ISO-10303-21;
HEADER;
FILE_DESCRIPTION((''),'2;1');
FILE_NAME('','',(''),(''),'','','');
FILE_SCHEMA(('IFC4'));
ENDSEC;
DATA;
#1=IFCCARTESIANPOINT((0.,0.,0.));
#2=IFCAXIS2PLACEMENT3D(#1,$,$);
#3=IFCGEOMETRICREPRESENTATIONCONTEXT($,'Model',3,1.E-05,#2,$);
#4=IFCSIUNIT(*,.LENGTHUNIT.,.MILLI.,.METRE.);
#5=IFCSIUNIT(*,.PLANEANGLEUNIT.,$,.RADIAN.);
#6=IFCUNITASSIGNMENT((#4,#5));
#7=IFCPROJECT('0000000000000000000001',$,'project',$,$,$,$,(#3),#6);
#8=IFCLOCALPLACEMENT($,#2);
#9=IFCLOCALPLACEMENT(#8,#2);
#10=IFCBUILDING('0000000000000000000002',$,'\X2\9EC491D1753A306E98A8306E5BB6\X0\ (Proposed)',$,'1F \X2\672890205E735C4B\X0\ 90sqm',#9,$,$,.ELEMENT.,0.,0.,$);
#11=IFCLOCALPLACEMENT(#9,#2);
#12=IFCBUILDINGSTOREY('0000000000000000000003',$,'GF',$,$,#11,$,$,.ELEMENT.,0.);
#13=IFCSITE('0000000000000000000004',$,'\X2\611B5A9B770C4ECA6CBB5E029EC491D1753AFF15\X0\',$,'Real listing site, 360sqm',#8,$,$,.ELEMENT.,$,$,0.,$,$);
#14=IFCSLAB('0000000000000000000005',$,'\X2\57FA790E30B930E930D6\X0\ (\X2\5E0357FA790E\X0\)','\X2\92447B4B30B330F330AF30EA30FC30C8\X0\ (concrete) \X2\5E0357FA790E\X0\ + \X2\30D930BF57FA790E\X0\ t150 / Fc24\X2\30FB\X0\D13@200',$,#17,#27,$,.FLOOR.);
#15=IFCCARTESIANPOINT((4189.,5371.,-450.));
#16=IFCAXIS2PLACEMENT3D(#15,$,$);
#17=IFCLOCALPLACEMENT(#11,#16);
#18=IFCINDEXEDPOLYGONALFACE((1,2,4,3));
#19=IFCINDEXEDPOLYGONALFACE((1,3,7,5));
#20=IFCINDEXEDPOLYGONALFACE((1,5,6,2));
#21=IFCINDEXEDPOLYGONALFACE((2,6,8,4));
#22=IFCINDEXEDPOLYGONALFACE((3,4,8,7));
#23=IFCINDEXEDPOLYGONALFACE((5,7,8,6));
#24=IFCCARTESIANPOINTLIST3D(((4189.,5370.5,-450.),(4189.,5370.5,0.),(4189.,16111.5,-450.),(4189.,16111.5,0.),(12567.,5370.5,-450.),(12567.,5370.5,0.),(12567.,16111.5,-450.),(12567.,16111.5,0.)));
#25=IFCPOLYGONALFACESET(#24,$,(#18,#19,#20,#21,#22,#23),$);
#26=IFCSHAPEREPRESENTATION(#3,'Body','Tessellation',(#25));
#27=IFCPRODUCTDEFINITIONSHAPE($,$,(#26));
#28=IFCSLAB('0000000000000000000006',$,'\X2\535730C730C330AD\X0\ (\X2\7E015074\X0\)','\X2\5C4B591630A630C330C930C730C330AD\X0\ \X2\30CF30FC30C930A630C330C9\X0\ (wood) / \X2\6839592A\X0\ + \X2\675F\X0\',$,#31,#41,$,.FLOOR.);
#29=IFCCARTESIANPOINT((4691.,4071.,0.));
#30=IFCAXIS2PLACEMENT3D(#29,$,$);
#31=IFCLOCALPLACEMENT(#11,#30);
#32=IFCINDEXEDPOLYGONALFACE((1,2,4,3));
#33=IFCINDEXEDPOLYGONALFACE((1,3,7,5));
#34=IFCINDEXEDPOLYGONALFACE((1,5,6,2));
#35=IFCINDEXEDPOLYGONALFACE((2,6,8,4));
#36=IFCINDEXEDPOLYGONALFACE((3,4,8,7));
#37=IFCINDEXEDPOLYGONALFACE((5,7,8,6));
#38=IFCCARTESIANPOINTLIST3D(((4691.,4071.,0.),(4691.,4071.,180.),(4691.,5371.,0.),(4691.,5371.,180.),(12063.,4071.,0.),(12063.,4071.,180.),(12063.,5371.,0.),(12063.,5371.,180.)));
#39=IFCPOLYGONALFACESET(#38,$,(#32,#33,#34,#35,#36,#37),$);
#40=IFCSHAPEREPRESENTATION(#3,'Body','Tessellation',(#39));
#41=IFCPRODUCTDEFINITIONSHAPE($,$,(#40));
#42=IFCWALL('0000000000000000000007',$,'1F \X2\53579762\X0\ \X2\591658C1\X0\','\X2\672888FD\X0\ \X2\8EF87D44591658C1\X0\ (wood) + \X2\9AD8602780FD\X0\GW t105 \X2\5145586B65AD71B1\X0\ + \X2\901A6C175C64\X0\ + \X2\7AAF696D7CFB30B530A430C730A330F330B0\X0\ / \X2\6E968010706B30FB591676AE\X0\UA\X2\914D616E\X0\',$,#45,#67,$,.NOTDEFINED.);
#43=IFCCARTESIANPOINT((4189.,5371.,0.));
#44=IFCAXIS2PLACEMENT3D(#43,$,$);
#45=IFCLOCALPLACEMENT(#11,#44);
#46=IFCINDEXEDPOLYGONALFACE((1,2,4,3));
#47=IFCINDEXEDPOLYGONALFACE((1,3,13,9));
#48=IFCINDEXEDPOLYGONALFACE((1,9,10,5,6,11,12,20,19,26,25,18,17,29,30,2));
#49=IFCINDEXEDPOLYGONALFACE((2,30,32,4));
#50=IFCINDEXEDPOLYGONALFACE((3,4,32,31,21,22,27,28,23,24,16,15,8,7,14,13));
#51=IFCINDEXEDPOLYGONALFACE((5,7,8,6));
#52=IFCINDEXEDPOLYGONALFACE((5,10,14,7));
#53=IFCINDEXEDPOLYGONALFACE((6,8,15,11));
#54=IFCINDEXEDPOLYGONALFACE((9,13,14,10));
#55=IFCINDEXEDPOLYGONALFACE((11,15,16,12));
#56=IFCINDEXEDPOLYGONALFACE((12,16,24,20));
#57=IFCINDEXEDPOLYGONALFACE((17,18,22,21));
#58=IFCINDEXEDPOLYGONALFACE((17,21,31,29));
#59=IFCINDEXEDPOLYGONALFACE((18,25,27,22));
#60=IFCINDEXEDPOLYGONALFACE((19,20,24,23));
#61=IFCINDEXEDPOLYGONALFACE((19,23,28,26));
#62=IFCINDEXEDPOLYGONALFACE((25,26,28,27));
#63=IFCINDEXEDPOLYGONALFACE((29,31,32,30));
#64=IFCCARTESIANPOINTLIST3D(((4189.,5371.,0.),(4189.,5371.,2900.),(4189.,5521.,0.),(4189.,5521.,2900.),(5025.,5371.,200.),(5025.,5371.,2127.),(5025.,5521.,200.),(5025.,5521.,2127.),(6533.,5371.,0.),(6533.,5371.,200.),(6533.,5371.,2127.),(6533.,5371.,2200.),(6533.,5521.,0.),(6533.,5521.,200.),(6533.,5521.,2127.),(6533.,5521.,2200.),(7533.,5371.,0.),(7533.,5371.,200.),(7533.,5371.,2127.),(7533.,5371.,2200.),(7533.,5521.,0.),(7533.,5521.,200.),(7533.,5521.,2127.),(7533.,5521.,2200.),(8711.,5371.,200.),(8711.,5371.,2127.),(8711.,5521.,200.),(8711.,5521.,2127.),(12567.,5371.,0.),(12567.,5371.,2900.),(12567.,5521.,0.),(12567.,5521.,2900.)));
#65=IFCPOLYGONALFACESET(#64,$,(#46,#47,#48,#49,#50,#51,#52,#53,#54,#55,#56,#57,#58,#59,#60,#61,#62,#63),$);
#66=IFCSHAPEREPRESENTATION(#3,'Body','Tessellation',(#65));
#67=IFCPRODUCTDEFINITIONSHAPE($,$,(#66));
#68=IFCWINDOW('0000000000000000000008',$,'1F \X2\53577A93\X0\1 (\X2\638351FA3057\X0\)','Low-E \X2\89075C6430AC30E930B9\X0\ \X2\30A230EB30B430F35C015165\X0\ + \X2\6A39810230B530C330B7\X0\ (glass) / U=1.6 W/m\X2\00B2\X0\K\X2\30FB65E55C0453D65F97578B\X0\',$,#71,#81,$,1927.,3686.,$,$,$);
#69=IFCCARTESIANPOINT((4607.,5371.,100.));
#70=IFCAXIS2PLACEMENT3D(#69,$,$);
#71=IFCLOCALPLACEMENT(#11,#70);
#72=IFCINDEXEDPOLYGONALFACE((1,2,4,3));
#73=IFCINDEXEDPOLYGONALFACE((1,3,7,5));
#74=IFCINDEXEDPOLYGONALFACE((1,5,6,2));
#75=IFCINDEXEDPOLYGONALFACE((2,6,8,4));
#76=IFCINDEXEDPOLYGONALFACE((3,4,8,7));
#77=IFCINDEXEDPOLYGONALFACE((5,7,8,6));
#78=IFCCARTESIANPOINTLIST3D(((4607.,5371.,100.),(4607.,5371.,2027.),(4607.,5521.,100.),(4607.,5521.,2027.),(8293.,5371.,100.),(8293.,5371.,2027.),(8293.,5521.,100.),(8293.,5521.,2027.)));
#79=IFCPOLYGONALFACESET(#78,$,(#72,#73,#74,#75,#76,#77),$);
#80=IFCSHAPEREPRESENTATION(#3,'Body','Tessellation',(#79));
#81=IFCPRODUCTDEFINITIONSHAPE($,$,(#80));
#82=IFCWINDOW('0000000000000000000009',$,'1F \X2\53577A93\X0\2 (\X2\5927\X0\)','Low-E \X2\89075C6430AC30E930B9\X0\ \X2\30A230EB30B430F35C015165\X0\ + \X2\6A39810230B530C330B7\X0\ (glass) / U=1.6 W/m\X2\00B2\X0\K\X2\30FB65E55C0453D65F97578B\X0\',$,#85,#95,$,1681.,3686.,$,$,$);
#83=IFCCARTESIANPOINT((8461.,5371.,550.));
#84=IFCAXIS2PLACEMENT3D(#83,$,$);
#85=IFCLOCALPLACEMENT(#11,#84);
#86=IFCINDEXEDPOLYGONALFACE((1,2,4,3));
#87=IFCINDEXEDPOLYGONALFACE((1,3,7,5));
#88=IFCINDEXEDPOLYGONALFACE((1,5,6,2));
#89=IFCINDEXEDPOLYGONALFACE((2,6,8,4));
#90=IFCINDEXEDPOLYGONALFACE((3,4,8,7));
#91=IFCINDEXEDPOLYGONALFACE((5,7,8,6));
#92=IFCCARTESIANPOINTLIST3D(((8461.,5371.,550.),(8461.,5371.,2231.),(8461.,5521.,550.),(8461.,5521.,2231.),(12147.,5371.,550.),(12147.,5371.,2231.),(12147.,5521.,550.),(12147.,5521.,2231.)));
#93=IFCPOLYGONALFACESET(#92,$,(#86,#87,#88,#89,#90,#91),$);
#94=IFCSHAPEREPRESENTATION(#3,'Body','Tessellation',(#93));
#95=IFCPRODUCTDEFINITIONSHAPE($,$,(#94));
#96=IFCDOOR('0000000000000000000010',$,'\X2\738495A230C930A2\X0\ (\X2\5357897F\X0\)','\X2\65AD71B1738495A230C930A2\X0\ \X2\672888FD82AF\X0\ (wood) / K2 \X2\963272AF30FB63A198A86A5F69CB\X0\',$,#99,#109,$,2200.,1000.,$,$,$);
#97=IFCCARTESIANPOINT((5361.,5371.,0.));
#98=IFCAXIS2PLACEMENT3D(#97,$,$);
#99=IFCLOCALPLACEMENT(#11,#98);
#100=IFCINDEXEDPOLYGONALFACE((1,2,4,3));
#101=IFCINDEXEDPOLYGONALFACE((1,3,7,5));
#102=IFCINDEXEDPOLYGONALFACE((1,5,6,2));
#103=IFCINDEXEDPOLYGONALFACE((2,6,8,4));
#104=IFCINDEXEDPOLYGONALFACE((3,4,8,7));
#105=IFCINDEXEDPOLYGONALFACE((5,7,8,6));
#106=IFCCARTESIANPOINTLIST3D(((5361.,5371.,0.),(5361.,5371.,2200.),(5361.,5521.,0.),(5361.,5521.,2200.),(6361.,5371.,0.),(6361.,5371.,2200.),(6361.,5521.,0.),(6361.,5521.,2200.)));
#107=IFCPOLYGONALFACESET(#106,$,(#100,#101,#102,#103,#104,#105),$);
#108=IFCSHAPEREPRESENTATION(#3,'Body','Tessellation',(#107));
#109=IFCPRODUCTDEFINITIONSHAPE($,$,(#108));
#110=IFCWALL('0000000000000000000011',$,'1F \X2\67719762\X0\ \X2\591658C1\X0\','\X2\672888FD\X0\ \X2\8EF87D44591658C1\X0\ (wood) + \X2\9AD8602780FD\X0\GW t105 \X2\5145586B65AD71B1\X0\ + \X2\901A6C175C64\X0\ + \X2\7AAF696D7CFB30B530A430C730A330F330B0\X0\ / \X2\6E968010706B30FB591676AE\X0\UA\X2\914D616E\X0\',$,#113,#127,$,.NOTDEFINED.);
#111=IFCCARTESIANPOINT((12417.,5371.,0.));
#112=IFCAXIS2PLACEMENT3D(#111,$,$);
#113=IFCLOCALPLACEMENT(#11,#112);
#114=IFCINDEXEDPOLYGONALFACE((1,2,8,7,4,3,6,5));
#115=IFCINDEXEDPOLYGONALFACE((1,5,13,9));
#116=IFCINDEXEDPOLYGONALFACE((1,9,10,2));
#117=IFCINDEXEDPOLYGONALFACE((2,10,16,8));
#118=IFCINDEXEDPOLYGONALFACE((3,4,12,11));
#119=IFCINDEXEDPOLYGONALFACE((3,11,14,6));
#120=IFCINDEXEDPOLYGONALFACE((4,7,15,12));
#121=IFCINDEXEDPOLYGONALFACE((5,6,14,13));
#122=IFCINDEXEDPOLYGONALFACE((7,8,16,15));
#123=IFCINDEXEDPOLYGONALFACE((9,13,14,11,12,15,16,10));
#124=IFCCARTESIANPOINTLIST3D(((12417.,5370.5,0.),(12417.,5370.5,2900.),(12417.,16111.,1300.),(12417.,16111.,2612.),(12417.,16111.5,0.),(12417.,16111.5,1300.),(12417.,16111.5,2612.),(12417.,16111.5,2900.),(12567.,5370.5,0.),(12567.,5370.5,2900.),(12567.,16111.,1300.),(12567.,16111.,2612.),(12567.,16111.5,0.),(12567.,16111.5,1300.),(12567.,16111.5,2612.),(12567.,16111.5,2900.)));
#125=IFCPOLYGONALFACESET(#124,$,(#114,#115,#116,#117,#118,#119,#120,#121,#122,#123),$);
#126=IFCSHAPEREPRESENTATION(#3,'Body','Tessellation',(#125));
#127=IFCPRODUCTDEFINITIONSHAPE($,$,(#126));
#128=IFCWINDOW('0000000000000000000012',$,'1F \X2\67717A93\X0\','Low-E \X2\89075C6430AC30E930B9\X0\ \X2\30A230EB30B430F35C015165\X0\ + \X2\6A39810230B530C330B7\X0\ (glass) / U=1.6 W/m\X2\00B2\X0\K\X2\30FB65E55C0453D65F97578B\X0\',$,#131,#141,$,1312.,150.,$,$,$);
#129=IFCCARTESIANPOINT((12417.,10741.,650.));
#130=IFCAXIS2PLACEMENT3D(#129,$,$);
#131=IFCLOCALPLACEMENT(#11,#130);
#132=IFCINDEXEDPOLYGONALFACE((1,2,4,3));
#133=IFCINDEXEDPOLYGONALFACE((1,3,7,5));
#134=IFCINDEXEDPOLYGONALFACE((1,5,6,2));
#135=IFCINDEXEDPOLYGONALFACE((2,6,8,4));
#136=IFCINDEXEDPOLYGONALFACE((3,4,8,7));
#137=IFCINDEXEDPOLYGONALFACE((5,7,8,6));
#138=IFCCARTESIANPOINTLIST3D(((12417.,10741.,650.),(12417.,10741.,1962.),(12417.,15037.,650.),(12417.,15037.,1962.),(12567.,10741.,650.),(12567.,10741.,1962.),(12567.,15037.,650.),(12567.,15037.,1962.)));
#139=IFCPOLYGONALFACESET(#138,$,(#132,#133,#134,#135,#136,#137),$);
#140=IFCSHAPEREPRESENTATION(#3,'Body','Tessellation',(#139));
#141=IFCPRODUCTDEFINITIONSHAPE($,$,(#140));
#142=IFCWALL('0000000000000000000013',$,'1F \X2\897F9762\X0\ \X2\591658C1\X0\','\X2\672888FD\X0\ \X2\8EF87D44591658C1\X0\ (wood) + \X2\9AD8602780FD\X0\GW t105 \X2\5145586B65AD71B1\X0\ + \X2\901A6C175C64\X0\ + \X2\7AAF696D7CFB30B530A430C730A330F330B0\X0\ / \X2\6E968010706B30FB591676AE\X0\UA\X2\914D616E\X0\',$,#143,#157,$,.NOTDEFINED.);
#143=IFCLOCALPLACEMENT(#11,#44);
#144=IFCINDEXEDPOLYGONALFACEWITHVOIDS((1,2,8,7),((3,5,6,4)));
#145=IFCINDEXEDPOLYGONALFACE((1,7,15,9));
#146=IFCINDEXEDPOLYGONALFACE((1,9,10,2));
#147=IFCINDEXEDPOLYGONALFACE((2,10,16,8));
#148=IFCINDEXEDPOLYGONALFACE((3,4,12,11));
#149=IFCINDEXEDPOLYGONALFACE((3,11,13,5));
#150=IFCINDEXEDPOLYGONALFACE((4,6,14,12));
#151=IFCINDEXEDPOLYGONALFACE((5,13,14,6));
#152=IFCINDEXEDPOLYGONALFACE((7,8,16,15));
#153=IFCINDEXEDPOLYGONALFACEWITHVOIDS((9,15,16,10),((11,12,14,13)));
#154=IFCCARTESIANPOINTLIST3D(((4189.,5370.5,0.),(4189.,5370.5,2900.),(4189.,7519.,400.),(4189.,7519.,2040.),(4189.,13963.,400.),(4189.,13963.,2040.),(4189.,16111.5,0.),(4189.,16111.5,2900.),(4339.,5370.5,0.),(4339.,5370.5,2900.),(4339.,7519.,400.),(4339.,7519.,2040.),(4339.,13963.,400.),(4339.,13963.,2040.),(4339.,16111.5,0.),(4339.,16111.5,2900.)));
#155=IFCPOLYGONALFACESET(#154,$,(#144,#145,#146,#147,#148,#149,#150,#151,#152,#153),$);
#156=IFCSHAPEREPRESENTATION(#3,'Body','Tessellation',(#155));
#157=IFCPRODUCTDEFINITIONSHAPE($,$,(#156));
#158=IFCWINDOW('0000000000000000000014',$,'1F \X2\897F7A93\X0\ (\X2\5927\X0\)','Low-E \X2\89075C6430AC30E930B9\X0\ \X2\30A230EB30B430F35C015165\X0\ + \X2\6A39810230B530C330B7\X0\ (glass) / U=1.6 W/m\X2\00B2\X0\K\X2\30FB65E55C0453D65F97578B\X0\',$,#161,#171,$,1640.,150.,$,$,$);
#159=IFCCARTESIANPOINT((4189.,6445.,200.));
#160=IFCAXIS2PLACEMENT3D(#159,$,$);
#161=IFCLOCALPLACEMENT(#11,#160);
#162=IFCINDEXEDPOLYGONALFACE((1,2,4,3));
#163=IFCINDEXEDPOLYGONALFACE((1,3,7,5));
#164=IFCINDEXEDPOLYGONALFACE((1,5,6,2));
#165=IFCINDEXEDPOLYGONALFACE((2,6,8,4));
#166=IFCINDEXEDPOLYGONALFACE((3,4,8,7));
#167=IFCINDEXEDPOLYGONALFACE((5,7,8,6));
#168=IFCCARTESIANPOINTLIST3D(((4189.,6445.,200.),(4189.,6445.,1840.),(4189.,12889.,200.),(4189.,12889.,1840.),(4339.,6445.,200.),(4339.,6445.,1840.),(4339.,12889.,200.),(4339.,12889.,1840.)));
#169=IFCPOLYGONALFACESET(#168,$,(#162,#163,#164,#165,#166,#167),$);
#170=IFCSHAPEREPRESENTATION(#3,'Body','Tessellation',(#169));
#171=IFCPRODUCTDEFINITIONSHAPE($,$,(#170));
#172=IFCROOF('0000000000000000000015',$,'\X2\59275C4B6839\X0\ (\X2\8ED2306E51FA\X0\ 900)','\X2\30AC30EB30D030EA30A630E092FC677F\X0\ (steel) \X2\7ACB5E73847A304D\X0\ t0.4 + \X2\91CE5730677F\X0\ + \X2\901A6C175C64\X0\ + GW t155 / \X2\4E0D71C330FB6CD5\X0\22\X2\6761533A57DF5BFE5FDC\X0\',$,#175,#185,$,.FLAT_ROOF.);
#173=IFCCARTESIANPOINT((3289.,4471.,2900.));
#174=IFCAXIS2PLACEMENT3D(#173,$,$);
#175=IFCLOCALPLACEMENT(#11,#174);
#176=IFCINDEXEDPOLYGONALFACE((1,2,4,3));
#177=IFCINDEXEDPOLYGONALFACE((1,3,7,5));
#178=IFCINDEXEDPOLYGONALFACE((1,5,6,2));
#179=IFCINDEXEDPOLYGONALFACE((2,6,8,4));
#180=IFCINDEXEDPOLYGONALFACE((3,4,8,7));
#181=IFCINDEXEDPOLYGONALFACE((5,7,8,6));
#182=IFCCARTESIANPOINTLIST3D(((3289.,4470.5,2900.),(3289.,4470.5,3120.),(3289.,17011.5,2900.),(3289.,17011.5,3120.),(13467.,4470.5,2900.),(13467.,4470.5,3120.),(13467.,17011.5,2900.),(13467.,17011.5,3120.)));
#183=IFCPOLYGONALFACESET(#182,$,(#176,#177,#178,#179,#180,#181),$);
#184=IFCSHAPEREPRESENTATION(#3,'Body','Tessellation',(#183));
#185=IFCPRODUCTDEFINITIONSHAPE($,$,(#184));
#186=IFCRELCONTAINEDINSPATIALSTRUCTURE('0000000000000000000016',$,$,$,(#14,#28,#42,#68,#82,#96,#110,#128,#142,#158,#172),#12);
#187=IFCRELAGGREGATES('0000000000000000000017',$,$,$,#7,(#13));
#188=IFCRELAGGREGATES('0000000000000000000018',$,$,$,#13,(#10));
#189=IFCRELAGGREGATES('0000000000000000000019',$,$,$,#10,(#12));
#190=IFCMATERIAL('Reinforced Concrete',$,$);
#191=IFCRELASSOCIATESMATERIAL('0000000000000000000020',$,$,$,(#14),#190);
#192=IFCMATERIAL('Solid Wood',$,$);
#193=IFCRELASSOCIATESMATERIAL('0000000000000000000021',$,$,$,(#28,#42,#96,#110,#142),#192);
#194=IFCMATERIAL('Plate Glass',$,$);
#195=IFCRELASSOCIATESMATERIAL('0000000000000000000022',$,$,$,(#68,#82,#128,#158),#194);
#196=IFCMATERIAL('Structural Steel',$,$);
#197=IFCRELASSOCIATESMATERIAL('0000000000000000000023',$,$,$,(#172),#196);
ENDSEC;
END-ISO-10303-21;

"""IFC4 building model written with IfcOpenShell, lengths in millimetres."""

from ifc_helpers import new_model, si_unit, frame, frame_2d, origin, place, context, project, spatial, rectangle, extrude, material, element, fill, save


model = new_model("IFC4")

# Units and contexts
model_context = context("Model", 3, precision=1e-05, world=origin())
ifc_project = project(units=[si_unit("LENGTHUNIT", "METRE", prefix="MILLI"), si_unit("PLANEANGLEUNIT", "RADIAN")], contexts=[model_context])

# Site, building, storey
site_placement = place(None, origin())
site = spatial("IfcSite", under=ifc_project, at=site_placement, Name="愛媛県今治市黄金町５", ObjectType="Real listing site, 360sqm", CompositionType="ELEMENT", RefElevation=0.0)
building_placement = place(site_placement, origin())
building = spatial("IfcBuilding", under=site, at=building_placement, Name="黄金町の風の家 (Proposed)", ObjectType="1F 木造平屋 90sqm", CompositionType="ELEMENT", ElevationOfRefHeight=0.0, ElevationOfTerrain=0.0)
storey_placement = place(building_placement, origin())
storey = spatial("IfcBuildingStorey", under=building, at=storey_placement, Name="GF", CompositionType="ELEMENT", Elevation=0.0)

# Slabs
ifc_material_1 = material(Name="Reinforced Concrete")
slab_1_placement = place(storey_placement, frame((4189.0, 5371.0, -450.0)))
element("IfcSlab", 1, at=slab_1_placement, inside=storey, material=ifc_material_1, Name="基礎スラブ (布基礎)", Description="鉄筋コンクリート (concrete) 布基礎 + ベタ基礎 t150 / Fc24・D13@200", PredefinedType="FLOOR", context=model_context, shape_type="SweptSolid", body=[
    extrude(rectangle(XDim=8378.0, YDim=10741.0, at=frame_2d((4189.0, 5370.0))), frame((4189.0, 5371.0, -450.0)), (0.0, 0.0, 1.0), 450.0),
])
ifc_material_2 = material(Name="Solid Wood")
slab_2_placement = place(storey_placement, frame((4691.0, 4071.0, 0.0)))
element("IfcSlab", 2, at=slab_2_placement, inside=storey, material=ifc_material_2, Name="南デッキ (縁側)", Description="屋外ウッドデッキ ハードウッド (wood) / 根太 + 束", PredefinedType="FLOOR", context=model_context, shape_type="SweptSolid", body=[
    extrude(rectangle(XDim=7372.0, YDim=1300.0, at=frame_2d((3686.0, 650.0))), frame((4691.0, 4071.0, 0.0)), (0.0, 0.0, 1.0), 180.0),
])

# Wall, openings, windows, door
wall_1_placement = place(storey_placement, frame((4189.0, 5371.0, 0.0)))
wall_1 = element("IfcWall", 3, at=wall_1_placement, inside=storey, material=ifc_material_2, Name="1F 南面 外壁", Description="木製 軸組外壁 (wood) + 高性能GW t105 充填断熱 + 通気層 + 窯業系サイディング / 準耐火・外皮UA配慮", PredefinedType="NOTDEFINED", context=model_context, shape_type="SweptSolid", body=[
    extrude(rectangle(XDim=8378.0, YDim=150.0, at=frame_2d((4189.0, 75.0))), frame((4189.0, 5371.0, 0.0)), (0.0, 0.0, 1.0), 2900.0),
])
opening_1_placement = place(storey_placement, frame((4607.0, 5371.0, 100.0)))
opening_1 = element("IfcOpeningElement", 4, at=opening_1_placement, cuts=wall_1, PredefinedType="NOTDEFINED", context=model_context, shape_type="SweptSolid", body=[
    extrude(rectangle(XDim=3686.0, YDim=150.0, at=frame_2d((1843.0, 75.0))), frame((4607.0, 5371.0, 100.0)), (0.0, 0.0, 1.0), 1927.0),
])
opening_2_placement = place(storey_placement, frame((8461.0, 5371.0, 550.0)))
opening_2 = element("IfcOpeningElement", 5, at=opening_2_placement, cuts=wall_1, PredefinedType="NOTDEFINED", context=model_context, shape_type="SweptSolid", body=[
    extrude(rectangle(XDim=3686.0, YDim=150.0, at=frame_2d((1843.0, 75.0))), frame((8461.0, 5371.0, 550.0)), (0.0, 0.0, 1.0), 1681.0),
])
opening_3_placement = place(storey_placement, frame((5361.0, 5371.0, 0.0)))
opening_3 = element("IfcOpeningElement", 6, at=opening_3_placement, cuts=wall_1, PredefinedType="NOTDEFINED", context=model_context, shape_type="SweptSolid", body=[
    extrude(rectangle(XDim=1000.0, YDim=150.0, at=frame_2d((500.0, 75.0))), frame((5361.0, 5371.0, 0.0)), (0.0, 0.0, 1.0), 2200.0),
])
ifc_material_3 = material(Name="Plate Glass")
window_1_placement = place(storey_placement, frame((4607.0, 5371.0, 100.0)))
window_1 = element("IfcWindow", 7, at=window_1_placement, inside=storey, material=ifc_material_3, Name="1F 南窓1 (掃出し)", Description="Low-E 複層ガラス アルゴン封入 + 樹脂サッシ (glass) / U=1.6 W/m²K・日射取得型", OverallHeight=1927.0, OverallWidth=3686.0, context=model_context, shape_type="SweptSolid", body=[
    extrude(rectangle(XDim=3686.0, YDim=150.0, at=frame_2d((1843.0, 75.0))), frame((4607.0, 5371.0, 100.0)), (0.0, 0.0, 1.0), 1927.0),
])
fill(opening_1, window_1)
window_2_placement = place(storey_placement, frame((8461.0, 5371.0, 550.0)))
window_2 = element("IfcWindow", 8, at=window_2_placement, inside=storey, material=ifc_material_3, Name="1F 南窓2 (大)", Description="Low-E 複層ガラス アルゴン封入 + 樹脂サッシ (glass) / U=1.6 W/m²K・日射取得型", OverallHeight=1681.0, OverallWidth=3686.0, context=model_context, shape_type="SweptSolid", body=[
    extrude(rectangle(XDim=3686.0, YDim=150.0, at=frame_2d((1843.0, 75.0))), frame((8461.0, 5371.0, 550.0)), (0.0, 0.0, 1.0), 1681.0),
])
fill(opening_2, window_2)
door_placement = place(storey_placement, frame((5361.0, 5371.0, 0.0)))
door = element("IfcDoor", 9, at=door_placement, inside=storey, material=ifc_material_2, Name="玄関ドア (南西)", Description="断熱玄関ドア 木製芯 (wood) / K2 防犯・採風機構", OverallHeight=2200.0, OverallWidth=1000.0, context=model_context, shape_type="SweptSolid", body=[
    extrude(rectangle(XDim=1000.0, YDim=150.0, at=frame_2d((500.0, 75.0))), frame((5361.0, 5371.0, 0.0)), (0.0, 0.0, 1.0), 2200.0),
])
fill(opening_3, door)

# Walls, openings, windows
wall_2_placement = place(storey_placement, frame((12417.0, 5371.0, 0.0)))
wall_2 = element("IfcWall", 10, at=wall_2_placement, inside=storey, material=ifc_material_2, Name="1F 東面 外壁", Description="木製 軸組外壁 (wood) + 高性能GW t105 充填断熱 + 通気層 + 窯業系サイディング / 準耐火・外皮UA配慮", PredefinedType="NOTDEFINED", context=model_context, shape_type="SweptSolid", body=[
    extrude(rectangle(XDim=150.0, YDim=10741.0, at=frame_2d((75.0, 5370.0))), frame((12417.0, 5371.0, 0.0)), (0.0, 0.0, 1.0), 2900.0),
])
opening_4_placement = place(storey_placement, frame((12417.0, 10741.0, 650.0)))
opening_4 = element("IfcOpeningElement", 11, at=opening_4_placement, cuts=wall_2, PredefinedType="NOTDEFINED", context=model_context, shape_type="SweptSolid", body=[
    extrude(rectangle(XDim=150.0, YDim=4296.0, at=frame_2d((75.0, 2148.0))), frame((12417.0, 10741.0, 650.0)), (0.0, 0.0, 1.0), 1312.0),
])
window_3_placement = place(storey_placement, frame((12417.0, 10741.0, 650.0)))
window_3 = element("IfcWindow", 12, at=window_3_placement, inside=storey, material=ifc_material_3, Name="1F 東窓", Description="Low-E 複層ガラス アルゴン封入 + 樹脂サッシ (glass) / U=1.6 W/m²K・日射取得型", OverallHeight=1312.0, OverallWidth=150.0, context=model_context, shape_type="SweptSolid", body=[
    extrude(rectangle(XDim=150.0, YDim=4296.0, at=frame_2d((75.0, 2148.0))), frame((12417.0, 10741.0, 650.0)), (0.0, 0.0, 1.0), 1312.0),
])
fill(opening_4, window_3)
wall_3_placement = place(storey_placement, frame((4189.0, 5371.0, 0.0)))
wall_3 = element("IfcWall", 13, at=wall_3_placement, inside=storey, material=ifc_material_2, Name="1F 西面 外壁", Description="木製 軸組外壁 (wood) + 高性能GW t105 充填断熱 + 通気層 + 窯業系サイディング / 準耐火・外皮UA配慮", PredefinedType="NOTDEFINED", context=model_context, shape_type="SweptSolid", body=[
    extrude(rectangle(XDim=150.0, YDim=10741.0, at=frame_2d((75.0, 5370.0))), frame((4189.0, 5371.0, 0.0)), (0.0, 0.0, 1.0), 2900.0),
])
opening_5_placement = place(storey_placement, frame((4189.0, 6445.0, 200.0)))
opening_5 = element("IfcOpeningElement", 14, at=opening_5_placement, cuts=wall_3, PredefinedType="NOTDEFINED", context=model_context, shape_type="SweptSolid", body=[
    extrude(rectangle(XDim=150.0, YDim=6444.0, at=frame_2d((75.0, 3222.0))), frame((4189.0, 6445.0, 200.0)), (0.0, 0.0, 1.0), 1640.0),
])
window_4_placement = place(storey_placement, frame((4189.0, 6445.0, 200.0)))
window_4 = element("IfcWindow", 15, at=window_4_placement, inside=storey, material=ifc_material_3, Name="1F 西窓 (大)", Description="Low-E 複層ガラス アルゴン封入 + 樹脂サッシ (glass) / U=1.6 W/m²K・日射取得型", OverallHeight=1640.0, OverallWidth=150.0, context=model_context, shape_type="SweptSolid", body=[
    extrude(rectangle(XDim=150.0, YDim=6444.0, at=frame_2d((75.0, 3222.0))), frame((4189.0, 6445.0, 200.0)), (0.0, 0.0, 1.0), 1640.0),
])
fill(opening_5, window_4)

# Roof
ifc_material_4 = material(Name="Structural Steel")
roof_placement = place(storey_placement, frame((3289.0, 4471.0, 2900.0)))
element("IfcRoof", 16, at=roof_placement, inside=storey, material=ifc_material_4, Name="大屋根 (軒の出 900)", Description="ガルバリウム鋼板 (steel) 立平葺き t0.4 + 野地板 + 通気層 + GW t155 / 不燃・法22条区域対応", PredefinedType="FLAT_ROOF", context=model_context, shape_type="SweptSolid", body=[
    extrude(rectangle(XDim=10178.0, YDim=12541.0, at=frame_2d((5089.0, 6270.0))), frame((3289.0, 4471.0, 2900.0)), (0.0, 0.0, 1.0), 220.0),
])

save(model, "model.ifc")
